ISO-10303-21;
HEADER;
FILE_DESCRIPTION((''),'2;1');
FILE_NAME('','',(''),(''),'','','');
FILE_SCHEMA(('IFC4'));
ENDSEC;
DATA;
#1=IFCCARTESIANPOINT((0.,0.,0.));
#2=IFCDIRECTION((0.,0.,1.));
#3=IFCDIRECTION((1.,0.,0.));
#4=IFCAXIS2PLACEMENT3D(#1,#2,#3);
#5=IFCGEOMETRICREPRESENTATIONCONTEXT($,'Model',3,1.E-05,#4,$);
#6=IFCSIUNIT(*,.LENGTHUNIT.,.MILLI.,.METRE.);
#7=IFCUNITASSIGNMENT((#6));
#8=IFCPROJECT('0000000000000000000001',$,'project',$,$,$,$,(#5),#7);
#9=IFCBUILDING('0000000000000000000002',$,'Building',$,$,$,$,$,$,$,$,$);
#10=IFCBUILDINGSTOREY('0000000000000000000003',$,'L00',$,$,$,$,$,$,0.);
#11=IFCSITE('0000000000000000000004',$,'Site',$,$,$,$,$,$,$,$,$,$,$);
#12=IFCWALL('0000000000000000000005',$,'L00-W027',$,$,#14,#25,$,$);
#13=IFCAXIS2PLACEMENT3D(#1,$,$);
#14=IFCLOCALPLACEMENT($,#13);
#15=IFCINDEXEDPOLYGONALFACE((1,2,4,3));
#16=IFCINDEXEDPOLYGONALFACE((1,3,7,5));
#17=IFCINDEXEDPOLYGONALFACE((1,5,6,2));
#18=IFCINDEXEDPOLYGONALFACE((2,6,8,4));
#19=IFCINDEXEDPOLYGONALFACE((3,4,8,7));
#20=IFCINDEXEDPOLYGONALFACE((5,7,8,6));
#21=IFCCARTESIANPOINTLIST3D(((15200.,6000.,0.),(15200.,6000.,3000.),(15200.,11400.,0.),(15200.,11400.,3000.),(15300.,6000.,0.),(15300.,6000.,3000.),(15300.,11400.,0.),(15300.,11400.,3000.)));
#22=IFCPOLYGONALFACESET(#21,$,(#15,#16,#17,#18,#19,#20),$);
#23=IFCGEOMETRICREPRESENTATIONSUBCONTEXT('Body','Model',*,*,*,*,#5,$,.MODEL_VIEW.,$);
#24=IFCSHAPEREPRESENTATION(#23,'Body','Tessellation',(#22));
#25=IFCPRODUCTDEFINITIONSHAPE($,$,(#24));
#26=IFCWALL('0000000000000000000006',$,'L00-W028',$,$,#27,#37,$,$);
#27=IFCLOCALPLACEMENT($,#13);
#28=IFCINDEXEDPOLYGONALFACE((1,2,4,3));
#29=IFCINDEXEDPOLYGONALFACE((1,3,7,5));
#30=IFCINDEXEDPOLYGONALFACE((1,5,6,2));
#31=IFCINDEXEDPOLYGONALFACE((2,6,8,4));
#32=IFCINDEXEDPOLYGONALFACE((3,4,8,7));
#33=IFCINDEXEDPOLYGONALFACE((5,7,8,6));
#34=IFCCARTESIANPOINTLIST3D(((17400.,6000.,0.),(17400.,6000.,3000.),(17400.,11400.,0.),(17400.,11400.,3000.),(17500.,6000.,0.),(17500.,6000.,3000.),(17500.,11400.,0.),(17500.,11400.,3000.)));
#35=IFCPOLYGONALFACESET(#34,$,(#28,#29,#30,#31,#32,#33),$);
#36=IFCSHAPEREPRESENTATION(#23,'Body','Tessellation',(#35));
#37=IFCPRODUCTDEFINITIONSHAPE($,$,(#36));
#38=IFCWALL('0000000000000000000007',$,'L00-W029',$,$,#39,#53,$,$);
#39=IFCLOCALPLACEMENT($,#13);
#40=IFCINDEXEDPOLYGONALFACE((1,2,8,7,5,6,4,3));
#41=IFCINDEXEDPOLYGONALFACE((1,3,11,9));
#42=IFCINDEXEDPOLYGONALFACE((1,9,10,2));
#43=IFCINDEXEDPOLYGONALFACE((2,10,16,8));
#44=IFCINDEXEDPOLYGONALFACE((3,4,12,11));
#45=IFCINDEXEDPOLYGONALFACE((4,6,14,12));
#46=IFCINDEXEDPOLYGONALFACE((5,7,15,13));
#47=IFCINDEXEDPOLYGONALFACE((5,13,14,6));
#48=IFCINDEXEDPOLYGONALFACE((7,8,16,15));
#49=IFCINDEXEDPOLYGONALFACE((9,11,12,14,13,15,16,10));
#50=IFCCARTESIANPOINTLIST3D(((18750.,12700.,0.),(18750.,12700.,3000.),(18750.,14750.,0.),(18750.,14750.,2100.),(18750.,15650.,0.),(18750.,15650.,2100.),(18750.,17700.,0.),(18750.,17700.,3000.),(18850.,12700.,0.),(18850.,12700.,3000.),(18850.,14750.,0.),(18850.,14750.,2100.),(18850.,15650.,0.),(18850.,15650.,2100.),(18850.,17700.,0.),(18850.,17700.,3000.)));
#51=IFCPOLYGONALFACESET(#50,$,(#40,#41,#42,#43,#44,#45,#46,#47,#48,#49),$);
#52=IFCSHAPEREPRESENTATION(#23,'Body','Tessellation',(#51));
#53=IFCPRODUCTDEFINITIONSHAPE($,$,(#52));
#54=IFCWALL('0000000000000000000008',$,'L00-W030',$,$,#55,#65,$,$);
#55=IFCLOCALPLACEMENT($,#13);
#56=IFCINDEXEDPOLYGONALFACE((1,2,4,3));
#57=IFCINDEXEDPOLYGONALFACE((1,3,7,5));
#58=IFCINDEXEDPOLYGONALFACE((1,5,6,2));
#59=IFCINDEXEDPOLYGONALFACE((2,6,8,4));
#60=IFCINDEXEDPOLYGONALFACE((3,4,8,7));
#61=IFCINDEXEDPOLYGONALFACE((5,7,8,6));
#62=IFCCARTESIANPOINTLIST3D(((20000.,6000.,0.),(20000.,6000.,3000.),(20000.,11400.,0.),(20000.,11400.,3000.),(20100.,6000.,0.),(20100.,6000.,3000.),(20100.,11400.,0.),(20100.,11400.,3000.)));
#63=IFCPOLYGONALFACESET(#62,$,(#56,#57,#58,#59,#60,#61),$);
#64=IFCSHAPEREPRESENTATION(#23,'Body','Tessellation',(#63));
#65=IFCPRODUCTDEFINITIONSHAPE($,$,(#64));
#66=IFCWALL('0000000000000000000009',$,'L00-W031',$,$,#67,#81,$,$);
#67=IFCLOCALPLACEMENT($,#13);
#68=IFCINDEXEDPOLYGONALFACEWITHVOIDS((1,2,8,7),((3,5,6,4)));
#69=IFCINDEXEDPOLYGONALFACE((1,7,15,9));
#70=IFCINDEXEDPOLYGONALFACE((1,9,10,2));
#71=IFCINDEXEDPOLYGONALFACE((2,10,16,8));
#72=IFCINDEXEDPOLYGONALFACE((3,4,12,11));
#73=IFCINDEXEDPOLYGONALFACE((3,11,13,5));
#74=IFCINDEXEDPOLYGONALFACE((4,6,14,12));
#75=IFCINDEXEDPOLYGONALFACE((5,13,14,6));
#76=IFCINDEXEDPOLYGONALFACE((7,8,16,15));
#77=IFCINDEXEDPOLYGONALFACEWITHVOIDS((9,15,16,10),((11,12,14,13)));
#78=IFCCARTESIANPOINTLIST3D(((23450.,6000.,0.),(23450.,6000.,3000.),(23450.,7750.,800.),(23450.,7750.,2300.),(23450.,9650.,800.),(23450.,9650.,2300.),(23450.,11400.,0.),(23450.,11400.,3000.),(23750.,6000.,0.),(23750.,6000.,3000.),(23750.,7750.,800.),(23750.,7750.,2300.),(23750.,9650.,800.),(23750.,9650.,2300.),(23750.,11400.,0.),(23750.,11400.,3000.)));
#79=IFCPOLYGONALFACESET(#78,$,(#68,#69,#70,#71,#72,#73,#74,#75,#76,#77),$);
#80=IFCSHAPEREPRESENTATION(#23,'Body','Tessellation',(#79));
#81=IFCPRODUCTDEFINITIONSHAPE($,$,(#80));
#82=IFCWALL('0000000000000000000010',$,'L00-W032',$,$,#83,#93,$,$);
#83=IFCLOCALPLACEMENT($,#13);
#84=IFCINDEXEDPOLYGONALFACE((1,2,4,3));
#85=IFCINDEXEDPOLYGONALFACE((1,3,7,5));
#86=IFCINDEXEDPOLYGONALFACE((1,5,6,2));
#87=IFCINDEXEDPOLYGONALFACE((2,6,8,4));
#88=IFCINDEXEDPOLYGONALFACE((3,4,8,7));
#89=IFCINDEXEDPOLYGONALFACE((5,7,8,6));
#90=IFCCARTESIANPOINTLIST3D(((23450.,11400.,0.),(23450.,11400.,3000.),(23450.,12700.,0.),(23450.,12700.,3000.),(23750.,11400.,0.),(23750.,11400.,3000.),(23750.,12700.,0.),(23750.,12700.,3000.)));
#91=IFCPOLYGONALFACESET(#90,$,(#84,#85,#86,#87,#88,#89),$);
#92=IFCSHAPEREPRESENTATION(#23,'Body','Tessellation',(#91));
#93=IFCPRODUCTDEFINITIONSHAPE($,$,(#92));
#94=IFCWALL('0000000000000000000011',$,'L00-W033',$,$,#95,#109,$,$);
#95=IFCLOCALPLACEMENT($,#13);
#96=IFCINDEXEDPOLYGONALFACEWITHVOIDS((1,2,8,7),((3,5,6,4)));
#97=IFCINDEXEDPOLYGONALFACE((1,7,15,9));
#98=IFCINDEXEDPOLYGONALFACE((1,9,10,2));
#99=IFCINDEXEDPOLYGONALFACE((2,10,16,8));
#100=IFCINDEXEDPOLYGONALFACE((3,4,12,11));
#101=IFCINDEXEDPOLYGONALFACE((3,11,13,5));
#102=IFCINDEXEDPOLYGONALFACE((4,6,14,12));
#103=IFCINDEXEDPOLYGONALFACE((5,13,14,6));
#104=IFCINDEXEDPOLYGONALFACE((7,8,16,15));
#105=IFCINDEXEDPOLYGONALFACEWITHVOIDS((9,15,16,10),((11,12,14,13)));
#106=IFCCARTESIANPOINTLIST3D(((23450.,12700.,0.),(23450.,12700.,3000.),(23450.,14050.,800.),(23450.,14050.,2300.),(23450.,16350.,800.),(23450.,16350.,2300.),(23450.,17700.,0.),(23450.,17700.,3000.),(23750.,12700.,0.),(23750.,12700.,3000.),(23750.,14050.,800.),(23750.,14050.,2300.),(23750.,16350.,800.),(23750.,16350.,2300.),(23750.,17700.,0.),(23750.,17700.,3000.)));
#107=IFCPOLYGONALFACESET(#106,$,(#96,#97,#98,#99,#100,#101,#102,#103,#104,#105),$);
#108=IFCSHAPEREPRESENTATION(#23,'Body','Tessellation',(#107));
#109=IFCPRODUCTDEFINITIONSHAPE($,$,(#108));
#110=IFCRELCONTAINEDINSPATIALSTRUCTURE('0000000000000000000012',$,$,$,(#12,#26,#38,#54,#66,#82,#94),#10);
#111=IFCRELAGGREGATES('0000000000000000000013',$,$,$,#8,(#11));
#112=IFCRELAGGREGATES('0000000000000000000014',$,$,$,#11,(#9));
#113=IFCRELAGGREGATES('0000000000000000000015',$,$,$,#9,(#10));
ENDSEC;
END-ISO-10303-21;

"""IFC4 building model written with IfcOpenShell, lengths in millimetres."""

from ifc_helpers import new_model, si_unit, frame, origin_with_axes, place, context, subcontext, project, spatial, indexed_curve, outline, extrude, element, save


model = new_model("IFC4")

# Units and contexts
model_context = context("Model", 3, precision=1e-05, world=origin_with_axes())
body_context = subcontext(model_context, "Body", "Model", "MODEL_VIEW")
ifc_project = project(units=[si_unit("LENGTHUNIT", "METRE", prefix="MILLI")], contexts=[model_context])

# Site, building, storey
site = spatial("IfcSite", under=ifc_project, Name="Site")
building = spatial("IfcBuilding", under=site, Name="Building")
storey = spatial("IfcBuildingStorey", under=building, Name="L00", Elevation=0.0)

# Walls
for number, where, z_axis, x_axis, name in (
    (1, (15300.0, 6000.0, 0.0), (0.0, 0.0, 1.0), (0.0, 1.0, 0.0), "L00-W027"),
    (2, (17500.0, 6000.0, 0.0), (0.0, 0.0, 1.0), (0.0, 1.0, 0.0), "L00-W028"),
):
    element("IfcWall", number, at=place(None, frame(where, z_axis=z_axis, x_axis=x_axis)), inside=storey, Name=name, context=body_context, shape_type="SweptSolid", body=[
        extrude(outline(indexed_curve([(0.0, 0.0), (0.0, 100.0), (5400.0, 100.0), (5400.0, 0.0), (0.0, 0.0)], self_intersect=False)), origin_with_axes(), (0.0, 0.0, 1.0), 3000.0),
    ])

# Wall, opening
wall_1_placement = place(None, frame((18850.0, 12700.0, 0.0), z_axis=(0.0, 0.0, 1.0), x_axis=(0.0, 1.0, 0.0)))
wall_1 = element("IfcWall", 3, at=wall_1_placement, inside=storey, Name="L00-W029", context=body_context, shape_type="SweptSolid", body=[
    extrude(outline(indexed_curve([(0.0, 0.0), (0.0, 100.0), (5000.0, 100.0), (5000.0, 0.0), (0.0, 0.0)], self_intersect=False)), origin_with_axes(), (0.0, 0.0, 1.0), 3000.0),
])
opening_1_placement = place(wall_1_placement, frame((2050.0, -10.0, 0.0), z_axis=(0.0, 0.0, 1.0), x_axis=(1.0, 0.0, 0.0)))
element("IfcOpeningElement", 4, at=opening_1_placement, cuts=wall_1, context=body_context, shape_type="SweptSolid", body=[
    extrude(outline(indexed_curve([(0.0, 0.0), (0.0, 120.0), (900.0, 120.0), (900.0, 0.0), (0.0, 0.0)], self_intersect=False)), origin_with_axes(), (0.0, 0.0, 1.0), 2100.0),
])

# Wall
wall_2_placement = place(None, frame((20100.0, 6000.0, 0.0), z_axis=(0.0, 0.0, 1.0), x_axis=(0.0, 1.0, 0.0)))
element("IfcWall", 5, at=wall_2_placement, inside=storey, Name="L00-W030", context=body_context, shape_type="SweptSolid", body=[
    extrude(outline(indexed_curve([(0.0, 0.0), (0.0, 100.0), (5400.0, 100.0), (5400.0, 0.0), (0.0, 0.0)], self_intersect=False)), origin_with_axes(), (0.0, 0.0, 1.0), 3000.0),
])

# Wall, opening
wall_3_placement = place(None, frame((23750.0, 6000.0, 0.0), z_axis=(0.0, 0.0, 1.0), x_axis=(0.0, 1.0, 0.0)))
wall_3 = element("IfcWall", 6, at=wall_3_placement, inside=storey, Name="L00-W031", context=body_context, shape_type="SweptSolid", body=[
    extrude(outline(indexed_curve([(0.0, 0.0), (0.0, 300.0), (5400.0, 300.0), (5400.0, 0.0), (0.0, 0.0)], self_intersect=False)), origin_with_axes(), (0.0, 0.0, 1.0), 3000.0),
])
opening_2_placement = place(wall_3_placement, frame((1750.0, -10.0, 800.0), z_axis=(0.0, 0.0, 1.0), x_axis=(1.0, 0.0, 0.0)))
element("IfcOpeningElement", 7, at=opening_2_placement, cuts=wall_3, context=body_context, shape_type="SweptSolid", body=[
    extrude(outline(indexed_curve([(0.0, 0.0), (0.0, 320.0), (1900.0, 320.0), (1900.0, 0.0), (0.0, 0.0)], self_intersect=False)), origin_with_axes(), (0.0, 0.0, 1.0), 1500.0),
])

# Wall
wall_4_placement = place(None, frame((23750.0, 11400.0, 0.0), z_axis=(0.0, 0.0, 1.0), x_axis=(0.0, 1.0, 0.0)))
element("IfcWall", 8, at=wall_4_placement, inside=storey, Name="L00-W032", context=body_context, shape_type="SweptSolid", body=[
    extrude(outline(indexed_curve([(0.0, 0.0), (0.0, 300.0), (1300.0, 300.0), (1300.0, 0.0), (0.0, 0.0)], self_intersect=False)), origin_with_axes(), (0.0, 0.0, 1.0), 3000.0),
])

# Wall, opening
wall_5_placement = place(None, frame((23750.0, 12700.0, 0.0), z_axis=(0.0, 0.0, 1.0), x_axis=(0.0, 1.0, 0.0)))
wall_5 = element("IfcWall", 9, at=wall_5_placement, inside=storey, Name="L00-W033", context=body_context, shape_type="SweptSolid", body=[
    extrude(outline(indexed_curve([(0.0, 0.0), (0.0, 300.0), (5000.0, 300.0), (5000.0, 0.0), (0.0, 0.0)], self_intersect=False)), origin_with_axes(), (0.0, 0.0, 1.0), 3000.0),
])
opening_3_placement = place(wall_5_placement, frame((1350.0, -10.0, 800.0), z_axis=(0.0, 0.0, 1.0), x_axis=(1.0, 0.0, 0.0)))
element("IfcOpeningElement", 10, at=opening_3_placement, cuts=wall_5, context=body_context, shape_type="SweptSolid", body=[
    extrude(outline(indexed_curve([(0.0, 0.0), (0.0, 320.0), (2300.0, 320.0), (2300.0, 0.0), (0.0, 0.0)], self_intersect=False)), origin_with_axes(), (0.0, 0.0, 1.0), 1500.0),
])

save(model, "model.ifc")
